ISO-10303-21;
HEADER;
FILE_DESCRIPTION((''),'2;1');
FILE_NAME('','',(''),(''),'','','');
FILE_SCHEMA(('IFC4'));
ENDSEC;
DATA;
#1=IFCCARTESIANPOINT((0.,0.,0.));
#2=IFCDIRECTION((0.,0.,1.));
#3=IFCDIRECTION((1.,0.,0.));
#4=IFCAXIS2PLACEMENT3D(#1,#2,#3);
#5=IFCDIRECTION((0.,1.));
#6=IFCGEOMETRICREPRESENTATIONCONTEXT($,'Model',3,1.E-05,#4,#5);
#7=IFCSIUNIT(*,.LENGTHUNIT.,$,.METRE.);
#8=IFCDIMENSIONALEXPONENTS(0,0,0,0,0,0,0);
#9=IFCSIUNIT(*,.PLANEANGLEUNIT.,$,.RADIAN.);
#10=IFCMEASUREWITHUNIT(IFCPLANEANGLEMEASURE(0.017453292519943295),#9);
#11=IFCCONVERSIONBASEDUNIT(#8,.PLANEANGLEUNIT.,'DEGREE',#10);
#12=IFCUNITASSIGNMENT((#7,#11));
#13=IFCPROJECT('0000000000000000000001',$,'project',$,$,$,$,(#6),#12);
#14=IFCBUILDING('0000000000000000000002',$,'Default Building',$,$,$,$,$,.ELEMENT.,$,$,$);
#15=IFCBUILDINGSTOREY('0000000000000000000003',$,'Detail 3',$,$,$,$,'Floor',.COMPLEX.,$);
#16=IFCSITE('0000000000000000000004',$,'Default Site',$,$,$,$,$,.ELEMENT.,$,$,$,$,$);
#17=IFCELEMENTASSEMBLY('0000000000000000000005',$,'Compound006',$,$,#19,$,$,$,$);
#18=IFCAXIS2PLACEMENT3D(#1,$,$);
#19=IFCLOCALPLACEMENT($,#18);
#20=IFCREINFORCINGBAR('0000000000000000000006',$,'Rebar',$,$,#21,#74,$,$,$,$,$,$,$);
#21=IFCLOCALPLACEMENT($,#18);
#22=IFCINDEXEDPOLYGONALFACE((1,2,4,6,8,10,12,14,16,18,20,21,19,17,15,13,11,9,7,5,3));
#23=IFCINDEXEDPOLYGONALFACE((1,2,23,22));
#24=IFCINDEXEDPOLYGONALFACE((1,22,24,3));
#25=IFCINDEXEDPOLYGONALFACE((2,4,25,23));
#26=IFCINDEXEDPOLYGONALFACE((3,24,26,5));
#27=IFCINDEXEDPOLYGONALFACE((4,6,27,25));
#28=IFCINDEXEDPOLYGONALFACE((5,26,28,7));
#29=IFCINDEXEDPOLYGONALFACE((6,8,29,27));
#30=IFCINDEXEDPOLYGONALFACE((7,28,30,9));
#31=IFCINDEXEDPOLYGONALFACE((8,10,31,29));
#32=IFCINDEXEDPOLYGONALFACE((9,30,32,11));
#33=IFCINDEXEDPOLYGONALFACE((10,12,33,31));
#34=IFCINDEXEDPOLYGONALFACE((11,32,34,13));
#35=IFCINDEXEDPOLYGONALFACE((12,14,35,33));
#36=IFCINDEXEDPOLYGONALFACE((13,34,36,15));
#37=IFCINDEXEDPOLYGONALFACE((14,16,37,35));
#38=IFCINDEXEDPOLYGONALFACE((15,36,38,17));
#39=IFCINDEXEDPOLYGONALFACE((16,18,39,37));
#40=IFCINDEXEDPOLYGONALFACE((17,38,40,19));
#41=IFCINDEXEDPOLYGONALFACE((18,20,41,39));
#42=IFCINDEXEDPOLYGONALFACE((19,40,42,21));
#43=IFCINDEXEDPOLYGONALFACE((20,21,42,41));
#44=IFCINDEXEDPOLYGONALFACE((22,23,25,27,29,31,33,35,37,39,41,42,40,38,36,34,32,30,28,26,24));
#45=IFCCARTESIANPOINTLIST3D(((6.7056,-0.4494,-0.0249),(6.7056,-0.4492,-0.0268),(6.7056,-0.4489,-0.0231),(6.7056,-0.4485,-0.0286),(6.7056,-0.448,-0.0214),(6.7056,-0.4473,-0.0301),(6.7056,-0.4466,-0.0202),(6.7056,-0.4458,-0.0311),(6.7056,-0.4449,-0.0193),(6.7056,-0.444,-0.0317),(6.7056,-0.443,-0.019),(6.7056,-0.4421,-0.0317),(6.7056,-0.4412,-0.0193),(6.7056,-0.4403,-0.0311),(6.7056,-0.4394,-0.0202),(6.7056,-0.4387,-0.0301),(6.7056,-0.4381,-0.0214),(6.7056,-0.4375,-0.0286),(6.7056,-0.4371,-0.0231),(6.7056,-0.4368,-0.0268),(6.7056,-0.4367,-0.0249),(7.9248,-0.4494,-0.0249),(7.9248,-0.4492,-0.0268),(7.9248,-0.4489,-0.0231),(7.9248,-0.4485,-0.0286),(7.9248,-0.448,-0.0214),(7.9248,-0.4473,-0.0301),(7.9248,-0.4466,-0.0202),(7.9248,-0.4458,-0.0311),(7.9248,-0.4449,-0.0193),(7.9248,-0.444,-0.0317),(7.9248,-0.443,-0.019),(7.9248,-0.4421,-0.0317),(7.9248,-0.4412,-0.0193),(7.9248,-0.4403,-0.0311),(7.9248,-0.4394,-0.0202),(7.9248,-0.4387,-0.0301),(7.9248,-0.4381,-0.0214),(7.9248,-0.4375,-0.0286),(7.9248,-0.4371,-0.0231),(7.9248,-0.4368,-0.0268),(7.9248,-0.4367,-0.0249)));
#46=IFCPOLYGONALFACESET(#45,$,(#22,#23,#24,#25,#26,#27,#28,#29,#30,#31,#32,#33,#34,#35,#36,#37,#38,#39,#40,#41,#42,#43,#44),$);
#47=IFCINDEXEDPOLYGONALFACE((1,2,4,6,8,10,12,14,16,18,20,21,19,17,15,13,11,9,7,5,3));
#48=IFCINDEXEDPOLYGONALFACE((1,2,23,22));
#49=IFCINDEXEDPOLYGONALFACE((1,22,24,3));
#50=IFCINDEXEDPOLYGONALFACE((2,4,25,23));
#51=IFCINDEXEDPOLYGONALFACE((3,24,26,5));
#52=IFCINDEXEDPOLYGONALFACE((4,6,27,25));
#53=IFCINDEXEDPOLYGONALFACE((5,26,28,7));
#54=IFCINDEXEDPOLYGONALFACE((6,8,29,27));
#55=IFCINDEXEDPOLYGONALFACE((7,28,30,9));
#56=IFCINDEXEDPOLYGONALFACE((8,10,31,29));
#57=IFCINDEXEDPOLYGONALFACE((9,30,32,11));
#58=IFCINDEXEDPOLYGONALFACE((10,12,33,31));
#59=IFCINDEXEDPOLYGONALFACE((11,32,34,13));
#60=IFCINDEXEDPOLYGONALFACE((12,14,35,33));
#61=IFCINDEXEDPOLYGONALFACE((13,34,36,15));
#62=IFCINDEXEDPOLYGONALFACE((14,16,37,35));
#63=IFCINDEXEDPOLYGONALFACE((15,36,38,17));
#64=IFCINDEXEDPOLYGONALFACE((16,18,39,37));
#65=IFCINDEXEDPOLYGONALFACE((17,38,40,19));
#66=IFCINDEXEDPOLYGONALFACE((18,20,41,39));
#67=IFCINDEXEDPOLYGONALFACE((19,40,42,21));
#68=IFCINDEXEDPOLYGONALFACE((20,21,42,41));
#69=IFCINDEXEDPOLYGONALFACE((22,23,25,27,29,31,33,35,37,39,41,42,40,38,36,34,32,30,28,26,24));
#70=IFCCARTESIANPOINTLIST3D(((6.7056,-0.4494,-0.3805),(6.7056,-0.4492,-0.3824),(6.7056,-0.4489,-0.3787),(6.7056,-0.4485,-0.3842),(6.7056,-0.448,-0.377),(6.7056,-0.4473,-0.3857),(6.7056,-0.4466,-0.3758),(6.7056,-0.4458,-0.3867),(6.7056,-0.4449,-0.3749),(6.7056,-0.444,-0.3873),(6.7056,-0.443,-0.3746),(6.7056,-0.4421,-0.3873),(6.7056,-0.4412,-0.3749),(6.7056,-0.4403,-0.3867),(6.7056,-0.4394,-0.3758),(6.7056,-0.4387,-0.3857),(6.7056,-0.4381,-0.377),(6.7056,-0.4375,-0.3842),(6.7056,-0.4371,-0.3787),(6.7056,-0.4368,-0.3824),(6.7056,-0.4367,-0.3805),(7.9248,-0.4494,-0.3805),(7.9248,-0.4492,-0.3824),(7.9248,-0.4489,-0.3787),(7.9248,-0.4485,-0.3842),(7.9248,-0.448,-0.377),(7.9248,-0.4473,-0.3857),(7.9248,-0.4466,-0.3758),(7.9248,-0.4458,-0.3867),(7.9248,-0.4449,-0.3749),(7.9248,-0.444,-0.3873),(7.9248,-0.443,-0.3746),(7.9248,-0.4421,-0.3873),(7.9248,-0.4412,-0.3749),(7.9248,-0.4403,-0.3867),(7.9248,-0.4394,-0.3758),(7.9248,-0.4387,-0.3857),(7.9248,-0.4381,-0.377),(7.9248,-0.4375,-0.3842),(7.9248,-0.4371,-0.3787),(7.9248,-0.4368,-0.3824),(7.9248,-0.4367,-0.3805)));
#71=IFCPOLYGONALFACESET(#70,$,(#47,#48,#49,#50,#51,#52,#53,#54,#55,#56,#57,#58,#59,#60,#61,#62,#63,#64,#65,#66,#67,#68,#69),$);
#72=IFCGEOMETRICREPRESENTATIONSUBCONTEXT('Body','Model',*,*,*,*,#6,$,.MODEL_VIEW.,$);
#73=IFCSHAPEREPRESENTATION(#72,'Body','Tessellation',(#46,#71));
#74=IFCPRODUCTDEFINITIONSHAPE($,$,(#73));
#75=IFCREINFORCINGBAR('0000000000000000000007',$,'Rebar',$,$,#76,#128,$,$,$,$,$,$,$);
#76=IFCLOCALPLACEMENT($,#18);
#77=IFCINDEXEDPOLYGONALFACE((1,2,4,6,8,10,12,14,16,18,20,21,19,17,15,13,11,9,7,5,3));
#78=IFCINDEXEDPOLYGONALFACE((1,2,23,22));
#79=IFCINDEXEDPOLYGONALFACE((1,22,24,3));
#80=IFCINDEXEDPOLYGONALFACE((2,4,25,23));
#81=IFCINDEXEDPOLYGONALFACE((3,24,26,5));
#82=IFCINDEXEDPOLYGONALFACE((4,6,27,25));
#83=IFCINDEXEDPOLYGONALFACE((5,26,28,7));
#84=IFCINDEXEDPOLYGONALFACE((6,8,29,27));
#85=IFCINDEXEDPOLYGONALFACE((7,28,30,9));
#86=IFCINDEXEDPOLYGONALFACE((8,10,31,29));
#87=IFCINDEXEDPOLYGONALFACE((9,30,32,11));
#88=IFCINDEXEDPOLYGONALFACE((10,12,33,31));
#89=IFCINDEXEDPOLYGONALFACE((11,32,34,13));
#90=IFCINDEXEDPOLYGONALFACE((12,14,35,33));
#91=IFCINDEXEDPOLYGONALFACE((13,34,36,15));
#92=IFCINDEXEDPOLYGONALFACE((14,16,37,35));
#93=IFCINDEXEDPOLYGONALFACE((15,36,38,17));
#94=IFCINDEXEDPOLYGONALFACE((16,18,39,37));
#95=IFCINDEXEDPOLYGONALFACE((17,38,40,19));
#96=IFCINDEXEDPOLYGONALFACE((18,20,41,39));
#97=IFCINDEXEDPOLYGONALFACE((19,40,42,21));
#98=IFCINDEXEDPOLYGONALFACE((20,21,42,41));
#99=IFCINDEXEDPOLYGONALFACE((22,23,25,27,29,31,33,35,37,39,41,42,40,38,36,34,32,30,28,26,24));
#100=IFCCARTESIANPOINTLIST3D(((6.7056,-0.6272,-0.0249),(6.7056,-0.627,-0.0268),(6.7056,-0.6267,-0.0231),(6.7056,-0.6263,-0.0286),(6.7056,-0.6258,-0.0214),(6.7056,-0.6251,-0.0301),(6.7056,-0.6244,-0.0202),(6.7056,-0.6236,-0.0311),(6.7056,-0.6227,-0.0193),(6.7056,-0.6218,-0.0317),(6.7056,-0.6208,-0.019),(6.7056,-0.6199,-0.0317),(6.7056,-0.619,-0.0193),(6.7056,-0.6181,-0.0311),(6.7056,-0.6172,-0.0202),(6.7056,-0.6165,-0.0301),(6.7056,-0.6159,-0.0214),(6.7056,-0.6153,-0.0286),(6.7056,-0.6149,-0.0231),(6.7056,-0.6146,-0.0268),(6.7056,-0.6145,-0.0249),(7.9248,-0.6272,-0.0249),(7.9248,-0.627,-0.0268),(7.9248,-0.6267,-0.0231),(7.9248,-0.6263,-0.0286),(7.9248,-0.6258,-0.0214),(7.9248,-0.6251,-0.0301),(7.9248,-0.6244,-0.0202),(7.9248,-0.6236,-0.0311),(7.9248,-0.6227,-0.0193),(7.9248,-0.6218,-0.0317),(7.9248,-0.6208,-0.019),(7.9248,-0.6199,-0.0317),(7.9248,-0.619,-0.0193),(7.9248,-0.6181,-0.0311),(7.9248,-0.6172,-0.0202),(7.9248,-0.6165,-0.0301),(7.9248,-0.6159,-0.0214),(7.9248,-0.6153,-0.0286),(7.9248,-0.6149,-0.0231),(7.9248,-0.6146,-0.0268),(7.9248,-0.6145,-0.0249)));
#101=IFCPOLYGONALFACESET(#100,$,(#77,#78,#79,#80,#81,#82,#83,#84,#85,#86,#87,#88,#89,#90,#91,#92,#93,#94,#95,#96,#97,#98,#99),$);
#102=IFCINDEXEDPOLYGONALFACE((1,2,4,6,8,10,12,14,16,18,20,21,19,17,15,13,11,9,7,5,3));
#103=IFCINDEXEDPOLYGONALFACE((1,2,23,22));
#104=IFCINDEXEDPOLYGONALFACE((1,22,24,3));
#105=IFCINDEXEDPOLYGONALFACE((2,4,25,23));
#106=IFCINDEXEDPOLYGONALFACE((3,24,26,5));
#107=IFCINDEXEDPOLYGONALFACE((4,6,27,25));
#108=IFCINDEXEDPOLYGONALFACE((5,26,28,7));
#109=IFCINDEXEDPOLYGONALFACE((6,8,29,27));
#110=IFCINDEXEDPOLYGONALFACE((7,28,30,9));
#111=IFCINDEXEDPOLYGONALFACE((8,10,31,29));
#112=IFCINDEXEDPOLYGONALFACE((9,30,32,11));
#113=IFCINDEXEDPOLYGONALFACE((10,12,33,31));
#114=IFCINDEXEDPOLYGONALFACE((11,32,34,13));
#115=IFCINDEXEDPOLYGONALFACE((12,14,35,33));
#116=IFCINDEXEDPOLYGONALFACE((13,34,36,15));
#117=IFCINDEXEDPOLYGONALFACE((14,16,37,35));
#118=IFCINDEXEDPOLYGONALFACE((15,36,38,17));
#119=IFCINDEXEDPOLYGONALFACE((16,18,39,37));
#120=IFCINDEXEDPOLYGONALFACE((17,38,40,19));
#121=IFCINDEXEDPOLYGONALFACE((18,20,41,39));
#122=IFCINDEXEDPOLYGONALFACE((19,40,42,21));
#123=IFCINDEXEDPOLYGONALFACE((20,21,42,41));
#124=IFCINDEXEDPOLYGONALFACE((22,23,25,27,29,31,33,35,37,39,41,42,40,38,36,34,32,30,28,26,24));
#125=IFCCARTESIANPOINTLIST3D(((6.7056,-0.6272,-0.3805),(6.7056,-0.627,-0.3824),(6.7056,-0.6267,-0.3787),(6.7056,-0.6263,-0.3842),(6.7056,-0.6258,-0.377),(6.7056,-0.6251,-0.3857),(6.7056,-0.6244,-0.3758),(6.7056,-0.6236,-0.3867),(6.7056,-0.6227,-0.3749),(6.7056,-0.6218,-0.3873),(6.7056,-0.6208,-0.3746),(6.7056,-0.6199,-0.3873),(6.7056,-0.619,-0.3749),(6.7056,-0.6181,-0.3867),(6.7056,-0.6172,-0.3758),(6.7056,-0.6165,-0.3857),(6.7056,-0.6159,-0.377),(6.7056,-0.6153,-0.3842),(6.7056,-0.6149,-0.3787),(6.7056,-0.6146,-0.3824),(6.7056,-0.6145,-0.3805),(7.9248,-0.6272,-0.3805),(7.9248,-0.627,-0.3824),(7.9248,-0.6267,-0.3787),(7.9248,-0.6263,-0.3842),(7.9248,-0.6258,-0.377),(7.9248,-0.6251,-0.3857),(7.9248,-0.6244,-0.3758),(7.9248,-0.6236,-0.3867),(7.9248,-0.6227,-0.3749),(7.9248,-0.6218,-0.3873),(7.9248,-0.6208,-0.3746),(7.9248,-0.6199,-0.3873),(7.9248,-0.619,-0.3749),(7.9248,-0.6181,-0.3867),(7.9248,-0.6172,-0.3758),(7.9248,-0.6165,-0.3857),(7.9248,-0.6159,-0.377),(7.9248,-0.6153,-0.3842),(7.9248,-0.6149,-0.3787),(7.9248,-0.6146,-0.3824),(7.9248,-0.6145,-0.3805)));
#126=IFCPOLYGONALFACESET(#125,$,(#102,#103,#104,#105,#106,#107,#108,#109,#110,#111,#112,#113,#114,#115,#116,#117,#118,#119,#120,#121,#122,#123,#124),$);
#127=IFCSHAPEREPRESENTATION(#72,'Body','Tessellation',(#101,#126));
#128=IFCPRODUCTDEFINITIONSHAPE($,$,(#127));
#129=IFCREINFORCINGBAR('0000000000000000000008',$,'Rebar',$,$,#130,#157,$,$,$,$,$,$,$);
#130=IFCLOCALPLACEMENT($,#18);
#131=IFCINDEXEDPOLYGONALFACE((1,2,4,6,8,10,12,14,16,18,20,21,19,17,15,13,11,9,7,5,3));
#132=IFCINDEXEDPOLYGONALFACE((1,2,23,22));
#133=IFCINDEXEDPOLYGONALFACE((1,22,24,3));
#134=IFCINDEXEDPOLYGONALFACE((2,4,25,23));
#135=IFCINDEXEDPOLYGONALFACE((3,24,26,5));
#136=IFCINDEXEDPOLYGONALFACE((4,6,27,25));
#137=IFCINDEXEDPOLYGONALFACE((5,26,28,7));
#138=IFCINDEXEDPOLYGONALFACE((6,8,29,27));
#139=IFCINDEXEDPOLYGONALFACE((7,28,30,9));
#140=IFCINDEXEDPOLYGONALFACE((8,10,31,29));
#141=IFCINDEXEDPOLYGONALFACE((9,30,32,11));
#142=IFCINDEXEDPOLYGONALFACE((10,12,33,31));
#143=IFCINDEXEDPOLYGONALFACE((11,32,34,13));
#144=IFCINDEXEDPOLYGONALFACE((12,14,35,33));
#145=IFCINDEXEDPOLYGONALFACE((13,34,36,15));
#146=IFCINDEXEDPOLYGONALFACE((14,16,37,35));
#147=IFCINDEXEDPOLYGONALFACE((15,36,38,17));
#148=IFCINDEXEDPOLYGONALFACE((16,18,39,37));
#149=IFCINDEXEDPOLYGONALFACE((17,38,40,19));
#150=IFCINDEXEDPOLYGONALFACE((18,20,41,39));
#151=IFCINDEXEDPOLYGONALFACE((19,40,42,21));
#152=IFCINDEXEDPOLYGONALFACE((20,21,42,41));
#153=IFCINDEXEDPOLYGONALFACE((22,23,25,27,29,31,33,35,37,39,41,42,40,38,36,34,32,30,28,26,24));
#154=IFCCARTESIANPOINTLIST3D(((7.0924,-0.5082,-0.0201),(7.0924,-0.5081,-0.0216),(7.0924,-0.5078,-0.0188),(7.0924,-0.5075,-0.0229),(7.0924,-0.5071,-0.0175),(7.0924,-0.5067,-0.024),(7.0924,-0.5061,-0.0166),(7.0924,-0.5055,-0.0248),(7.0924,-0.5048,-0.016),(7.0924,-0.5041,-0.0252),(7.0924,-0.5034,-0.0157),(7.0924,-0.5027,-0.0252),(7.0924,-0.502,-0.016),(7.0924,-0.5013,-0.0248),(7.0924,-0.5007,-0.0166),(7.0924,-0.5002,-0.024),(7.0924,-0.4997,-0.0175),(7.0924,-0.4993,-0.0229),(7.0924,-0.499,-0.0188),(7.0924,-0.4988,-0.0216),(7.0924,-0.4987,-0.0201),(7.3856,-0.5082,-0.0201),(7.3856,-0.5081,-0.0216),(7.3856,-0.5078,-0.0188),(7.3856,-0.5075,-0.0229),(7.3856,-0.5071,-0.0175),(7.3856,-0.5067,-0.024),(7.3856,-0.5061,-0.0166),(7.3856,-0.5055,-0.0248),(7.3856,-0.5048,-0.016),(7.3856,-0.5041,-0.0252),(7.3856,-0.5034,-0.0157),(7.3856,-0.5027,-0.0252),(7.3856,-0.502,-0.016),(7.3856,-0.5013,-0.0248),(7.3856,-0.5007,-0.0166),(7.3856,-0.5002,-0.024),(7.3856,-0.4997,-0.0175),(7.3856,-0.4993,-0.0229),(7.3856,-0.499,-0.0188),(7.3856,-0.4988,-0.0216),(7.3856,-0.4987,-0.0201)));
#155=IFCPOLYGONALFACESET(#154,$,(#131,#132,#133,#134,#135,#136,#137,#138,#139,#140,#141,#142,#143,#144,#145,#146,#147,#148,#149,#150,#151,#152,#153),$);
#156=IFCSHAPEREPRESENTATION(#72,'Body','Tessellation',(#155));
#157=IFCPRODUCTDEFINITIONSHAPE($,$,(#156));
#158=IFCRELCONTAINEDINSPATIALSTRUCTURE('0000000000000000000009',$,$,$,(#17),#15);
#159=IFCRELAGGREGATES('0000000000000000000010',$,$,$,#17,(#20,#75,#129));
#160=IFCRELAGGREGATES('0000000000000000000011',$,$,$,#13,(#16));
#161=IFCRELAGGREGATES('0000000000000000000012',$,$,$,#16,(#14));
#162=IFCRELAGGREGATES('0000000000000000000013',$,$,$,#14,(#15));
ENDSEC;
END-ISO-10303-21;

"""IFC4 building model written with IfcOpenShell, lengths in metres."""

from ifc_helpers import new_model, entity, si_unit, converted_unit, direction, origin_with_axes, place, context, subcontext, project, spatial, element, aggregate, save


model = new_model("IFC4")

# Units and contexts
model_context = context("Model", 3, precision=1e-05, world=origin_with_axes(), true_north=direction((0.0, 1.0)))
body_context = subcontext(model_context, "Body", "Model", "MODEL_VIEW")
ifc_project = project(units=[si_unit("LENGTHUNIT", "METRE"), converted_unit("PLANEANGLEUNIT", "DEGREE", entity("IfcPlaneAngleMeasure", 0.017453292519943295), si_unit("PLANEANGLEUNIT", "RADIAN"), dimensions=[0, 0, 0, 0, 0, 0, 0])], contexts=[model_context])

# Site, building, storey
site = spatial("IfcSite", under=ifc_project, Name="Default Site", CompositionType="ELEMENT")
building = spatial("IfcBuilding", under=site, Name="Default Building", CompositionType="ELEMENT")
storey = spatial("IfcBuildingStorey", under=building, Name="Detail 3", LongName="Floor", CompositionType="COMPLEX")

# Shared definitions
placement = place(None, origin_with_axes())

# Element assembly, reinforcing bars
assembly = element("IfcElementAssembly", 1, inside=storey, Name="Compound006")
reinforcing_bar_1 = element("IfcReinforcingBar", 2, at=placement, Name="Rebar", context=body_context, shape_type="SweptSolid", body=[
    entity("IfcSweptDiskSolid", entity("IfcCompositeCurve", [entity("IfcCompositeCurveSegment", "CONTINUOUS", True, entity("IfcPolyline", [entity("IfcCartesianPoint", [6.7056, -0.443, -0.0254]), entity("IfcCartesianPoint", [7.9248, -0.443, -0.0254])]))], False), 0.0063),
    entity("IfcSweptDiskSolid", entity("IfcCompositeCurve", [entity("IfcCompositeCurveSegment", "CONTINUOUS", True, entity("IfcPolyline", [entity("IfcCartesianPoint", [6.7056, -0.443, -0.381]), entity("IfcCartesianPoint", [7.9248, -0.443, -0.381])]))], False), 0.0063),
])
reinforcing_bar_2 = element("IfcReinforcingBar", 3, at=placement, Name="Rebar", context=body_context, shape_type="SweptSolid", body=[
    entity("IfcSweptDiskSolid", entity("IfcCompositeCurve", [entity("IfcCompositeCurveSegment", "CONTINUOUS", True, entity("IfcPolyline", [entity("IfcCartesianPoint", [6.7056, -0.6208, -0.0254]), entity("IfcCartesianPoint", [7.9248, -0.6208, -0.0254])]))], False), 0.0063),
    entity("IfcSweptDiskSolid", entity("IfcCompositeCurve", [entity("IfcCompositeCurveSegment", "CONTINUOUS", True, entity("IfcPolyline", [entity("IfcCartesianPoint", [6.7056, -0.6208, -0.381]), entity("IfcCartesianPoint", [7.9248, -0.6208, -0.381])]))], False), 0.0063),
])
reinforcing_bar_3 = element("IfcReinforcingBar", 4, at=placement, Name="Rebar", context=body_context, shape_type="SweptSolid", body=[
    entity("IfcSweptDiskSolid", entity("IfcCompositeCurve", [entity("IfcCompositeCurveSegment", "CONTINUOUS", True, entity("IfcPolyline", [entity("IfcCartesianPoint", [7.0924, -0.5034, -0.0205]), entity("IfcCartesianPoint", [7.3856, -0.5034, -0.0205])]))], False), 0.0048),
])
aggregate(assembly, [reinforcing_bar_1, reinforcing_bar_2, reinforcing_bar_3])

save(model, "model.ifc")
